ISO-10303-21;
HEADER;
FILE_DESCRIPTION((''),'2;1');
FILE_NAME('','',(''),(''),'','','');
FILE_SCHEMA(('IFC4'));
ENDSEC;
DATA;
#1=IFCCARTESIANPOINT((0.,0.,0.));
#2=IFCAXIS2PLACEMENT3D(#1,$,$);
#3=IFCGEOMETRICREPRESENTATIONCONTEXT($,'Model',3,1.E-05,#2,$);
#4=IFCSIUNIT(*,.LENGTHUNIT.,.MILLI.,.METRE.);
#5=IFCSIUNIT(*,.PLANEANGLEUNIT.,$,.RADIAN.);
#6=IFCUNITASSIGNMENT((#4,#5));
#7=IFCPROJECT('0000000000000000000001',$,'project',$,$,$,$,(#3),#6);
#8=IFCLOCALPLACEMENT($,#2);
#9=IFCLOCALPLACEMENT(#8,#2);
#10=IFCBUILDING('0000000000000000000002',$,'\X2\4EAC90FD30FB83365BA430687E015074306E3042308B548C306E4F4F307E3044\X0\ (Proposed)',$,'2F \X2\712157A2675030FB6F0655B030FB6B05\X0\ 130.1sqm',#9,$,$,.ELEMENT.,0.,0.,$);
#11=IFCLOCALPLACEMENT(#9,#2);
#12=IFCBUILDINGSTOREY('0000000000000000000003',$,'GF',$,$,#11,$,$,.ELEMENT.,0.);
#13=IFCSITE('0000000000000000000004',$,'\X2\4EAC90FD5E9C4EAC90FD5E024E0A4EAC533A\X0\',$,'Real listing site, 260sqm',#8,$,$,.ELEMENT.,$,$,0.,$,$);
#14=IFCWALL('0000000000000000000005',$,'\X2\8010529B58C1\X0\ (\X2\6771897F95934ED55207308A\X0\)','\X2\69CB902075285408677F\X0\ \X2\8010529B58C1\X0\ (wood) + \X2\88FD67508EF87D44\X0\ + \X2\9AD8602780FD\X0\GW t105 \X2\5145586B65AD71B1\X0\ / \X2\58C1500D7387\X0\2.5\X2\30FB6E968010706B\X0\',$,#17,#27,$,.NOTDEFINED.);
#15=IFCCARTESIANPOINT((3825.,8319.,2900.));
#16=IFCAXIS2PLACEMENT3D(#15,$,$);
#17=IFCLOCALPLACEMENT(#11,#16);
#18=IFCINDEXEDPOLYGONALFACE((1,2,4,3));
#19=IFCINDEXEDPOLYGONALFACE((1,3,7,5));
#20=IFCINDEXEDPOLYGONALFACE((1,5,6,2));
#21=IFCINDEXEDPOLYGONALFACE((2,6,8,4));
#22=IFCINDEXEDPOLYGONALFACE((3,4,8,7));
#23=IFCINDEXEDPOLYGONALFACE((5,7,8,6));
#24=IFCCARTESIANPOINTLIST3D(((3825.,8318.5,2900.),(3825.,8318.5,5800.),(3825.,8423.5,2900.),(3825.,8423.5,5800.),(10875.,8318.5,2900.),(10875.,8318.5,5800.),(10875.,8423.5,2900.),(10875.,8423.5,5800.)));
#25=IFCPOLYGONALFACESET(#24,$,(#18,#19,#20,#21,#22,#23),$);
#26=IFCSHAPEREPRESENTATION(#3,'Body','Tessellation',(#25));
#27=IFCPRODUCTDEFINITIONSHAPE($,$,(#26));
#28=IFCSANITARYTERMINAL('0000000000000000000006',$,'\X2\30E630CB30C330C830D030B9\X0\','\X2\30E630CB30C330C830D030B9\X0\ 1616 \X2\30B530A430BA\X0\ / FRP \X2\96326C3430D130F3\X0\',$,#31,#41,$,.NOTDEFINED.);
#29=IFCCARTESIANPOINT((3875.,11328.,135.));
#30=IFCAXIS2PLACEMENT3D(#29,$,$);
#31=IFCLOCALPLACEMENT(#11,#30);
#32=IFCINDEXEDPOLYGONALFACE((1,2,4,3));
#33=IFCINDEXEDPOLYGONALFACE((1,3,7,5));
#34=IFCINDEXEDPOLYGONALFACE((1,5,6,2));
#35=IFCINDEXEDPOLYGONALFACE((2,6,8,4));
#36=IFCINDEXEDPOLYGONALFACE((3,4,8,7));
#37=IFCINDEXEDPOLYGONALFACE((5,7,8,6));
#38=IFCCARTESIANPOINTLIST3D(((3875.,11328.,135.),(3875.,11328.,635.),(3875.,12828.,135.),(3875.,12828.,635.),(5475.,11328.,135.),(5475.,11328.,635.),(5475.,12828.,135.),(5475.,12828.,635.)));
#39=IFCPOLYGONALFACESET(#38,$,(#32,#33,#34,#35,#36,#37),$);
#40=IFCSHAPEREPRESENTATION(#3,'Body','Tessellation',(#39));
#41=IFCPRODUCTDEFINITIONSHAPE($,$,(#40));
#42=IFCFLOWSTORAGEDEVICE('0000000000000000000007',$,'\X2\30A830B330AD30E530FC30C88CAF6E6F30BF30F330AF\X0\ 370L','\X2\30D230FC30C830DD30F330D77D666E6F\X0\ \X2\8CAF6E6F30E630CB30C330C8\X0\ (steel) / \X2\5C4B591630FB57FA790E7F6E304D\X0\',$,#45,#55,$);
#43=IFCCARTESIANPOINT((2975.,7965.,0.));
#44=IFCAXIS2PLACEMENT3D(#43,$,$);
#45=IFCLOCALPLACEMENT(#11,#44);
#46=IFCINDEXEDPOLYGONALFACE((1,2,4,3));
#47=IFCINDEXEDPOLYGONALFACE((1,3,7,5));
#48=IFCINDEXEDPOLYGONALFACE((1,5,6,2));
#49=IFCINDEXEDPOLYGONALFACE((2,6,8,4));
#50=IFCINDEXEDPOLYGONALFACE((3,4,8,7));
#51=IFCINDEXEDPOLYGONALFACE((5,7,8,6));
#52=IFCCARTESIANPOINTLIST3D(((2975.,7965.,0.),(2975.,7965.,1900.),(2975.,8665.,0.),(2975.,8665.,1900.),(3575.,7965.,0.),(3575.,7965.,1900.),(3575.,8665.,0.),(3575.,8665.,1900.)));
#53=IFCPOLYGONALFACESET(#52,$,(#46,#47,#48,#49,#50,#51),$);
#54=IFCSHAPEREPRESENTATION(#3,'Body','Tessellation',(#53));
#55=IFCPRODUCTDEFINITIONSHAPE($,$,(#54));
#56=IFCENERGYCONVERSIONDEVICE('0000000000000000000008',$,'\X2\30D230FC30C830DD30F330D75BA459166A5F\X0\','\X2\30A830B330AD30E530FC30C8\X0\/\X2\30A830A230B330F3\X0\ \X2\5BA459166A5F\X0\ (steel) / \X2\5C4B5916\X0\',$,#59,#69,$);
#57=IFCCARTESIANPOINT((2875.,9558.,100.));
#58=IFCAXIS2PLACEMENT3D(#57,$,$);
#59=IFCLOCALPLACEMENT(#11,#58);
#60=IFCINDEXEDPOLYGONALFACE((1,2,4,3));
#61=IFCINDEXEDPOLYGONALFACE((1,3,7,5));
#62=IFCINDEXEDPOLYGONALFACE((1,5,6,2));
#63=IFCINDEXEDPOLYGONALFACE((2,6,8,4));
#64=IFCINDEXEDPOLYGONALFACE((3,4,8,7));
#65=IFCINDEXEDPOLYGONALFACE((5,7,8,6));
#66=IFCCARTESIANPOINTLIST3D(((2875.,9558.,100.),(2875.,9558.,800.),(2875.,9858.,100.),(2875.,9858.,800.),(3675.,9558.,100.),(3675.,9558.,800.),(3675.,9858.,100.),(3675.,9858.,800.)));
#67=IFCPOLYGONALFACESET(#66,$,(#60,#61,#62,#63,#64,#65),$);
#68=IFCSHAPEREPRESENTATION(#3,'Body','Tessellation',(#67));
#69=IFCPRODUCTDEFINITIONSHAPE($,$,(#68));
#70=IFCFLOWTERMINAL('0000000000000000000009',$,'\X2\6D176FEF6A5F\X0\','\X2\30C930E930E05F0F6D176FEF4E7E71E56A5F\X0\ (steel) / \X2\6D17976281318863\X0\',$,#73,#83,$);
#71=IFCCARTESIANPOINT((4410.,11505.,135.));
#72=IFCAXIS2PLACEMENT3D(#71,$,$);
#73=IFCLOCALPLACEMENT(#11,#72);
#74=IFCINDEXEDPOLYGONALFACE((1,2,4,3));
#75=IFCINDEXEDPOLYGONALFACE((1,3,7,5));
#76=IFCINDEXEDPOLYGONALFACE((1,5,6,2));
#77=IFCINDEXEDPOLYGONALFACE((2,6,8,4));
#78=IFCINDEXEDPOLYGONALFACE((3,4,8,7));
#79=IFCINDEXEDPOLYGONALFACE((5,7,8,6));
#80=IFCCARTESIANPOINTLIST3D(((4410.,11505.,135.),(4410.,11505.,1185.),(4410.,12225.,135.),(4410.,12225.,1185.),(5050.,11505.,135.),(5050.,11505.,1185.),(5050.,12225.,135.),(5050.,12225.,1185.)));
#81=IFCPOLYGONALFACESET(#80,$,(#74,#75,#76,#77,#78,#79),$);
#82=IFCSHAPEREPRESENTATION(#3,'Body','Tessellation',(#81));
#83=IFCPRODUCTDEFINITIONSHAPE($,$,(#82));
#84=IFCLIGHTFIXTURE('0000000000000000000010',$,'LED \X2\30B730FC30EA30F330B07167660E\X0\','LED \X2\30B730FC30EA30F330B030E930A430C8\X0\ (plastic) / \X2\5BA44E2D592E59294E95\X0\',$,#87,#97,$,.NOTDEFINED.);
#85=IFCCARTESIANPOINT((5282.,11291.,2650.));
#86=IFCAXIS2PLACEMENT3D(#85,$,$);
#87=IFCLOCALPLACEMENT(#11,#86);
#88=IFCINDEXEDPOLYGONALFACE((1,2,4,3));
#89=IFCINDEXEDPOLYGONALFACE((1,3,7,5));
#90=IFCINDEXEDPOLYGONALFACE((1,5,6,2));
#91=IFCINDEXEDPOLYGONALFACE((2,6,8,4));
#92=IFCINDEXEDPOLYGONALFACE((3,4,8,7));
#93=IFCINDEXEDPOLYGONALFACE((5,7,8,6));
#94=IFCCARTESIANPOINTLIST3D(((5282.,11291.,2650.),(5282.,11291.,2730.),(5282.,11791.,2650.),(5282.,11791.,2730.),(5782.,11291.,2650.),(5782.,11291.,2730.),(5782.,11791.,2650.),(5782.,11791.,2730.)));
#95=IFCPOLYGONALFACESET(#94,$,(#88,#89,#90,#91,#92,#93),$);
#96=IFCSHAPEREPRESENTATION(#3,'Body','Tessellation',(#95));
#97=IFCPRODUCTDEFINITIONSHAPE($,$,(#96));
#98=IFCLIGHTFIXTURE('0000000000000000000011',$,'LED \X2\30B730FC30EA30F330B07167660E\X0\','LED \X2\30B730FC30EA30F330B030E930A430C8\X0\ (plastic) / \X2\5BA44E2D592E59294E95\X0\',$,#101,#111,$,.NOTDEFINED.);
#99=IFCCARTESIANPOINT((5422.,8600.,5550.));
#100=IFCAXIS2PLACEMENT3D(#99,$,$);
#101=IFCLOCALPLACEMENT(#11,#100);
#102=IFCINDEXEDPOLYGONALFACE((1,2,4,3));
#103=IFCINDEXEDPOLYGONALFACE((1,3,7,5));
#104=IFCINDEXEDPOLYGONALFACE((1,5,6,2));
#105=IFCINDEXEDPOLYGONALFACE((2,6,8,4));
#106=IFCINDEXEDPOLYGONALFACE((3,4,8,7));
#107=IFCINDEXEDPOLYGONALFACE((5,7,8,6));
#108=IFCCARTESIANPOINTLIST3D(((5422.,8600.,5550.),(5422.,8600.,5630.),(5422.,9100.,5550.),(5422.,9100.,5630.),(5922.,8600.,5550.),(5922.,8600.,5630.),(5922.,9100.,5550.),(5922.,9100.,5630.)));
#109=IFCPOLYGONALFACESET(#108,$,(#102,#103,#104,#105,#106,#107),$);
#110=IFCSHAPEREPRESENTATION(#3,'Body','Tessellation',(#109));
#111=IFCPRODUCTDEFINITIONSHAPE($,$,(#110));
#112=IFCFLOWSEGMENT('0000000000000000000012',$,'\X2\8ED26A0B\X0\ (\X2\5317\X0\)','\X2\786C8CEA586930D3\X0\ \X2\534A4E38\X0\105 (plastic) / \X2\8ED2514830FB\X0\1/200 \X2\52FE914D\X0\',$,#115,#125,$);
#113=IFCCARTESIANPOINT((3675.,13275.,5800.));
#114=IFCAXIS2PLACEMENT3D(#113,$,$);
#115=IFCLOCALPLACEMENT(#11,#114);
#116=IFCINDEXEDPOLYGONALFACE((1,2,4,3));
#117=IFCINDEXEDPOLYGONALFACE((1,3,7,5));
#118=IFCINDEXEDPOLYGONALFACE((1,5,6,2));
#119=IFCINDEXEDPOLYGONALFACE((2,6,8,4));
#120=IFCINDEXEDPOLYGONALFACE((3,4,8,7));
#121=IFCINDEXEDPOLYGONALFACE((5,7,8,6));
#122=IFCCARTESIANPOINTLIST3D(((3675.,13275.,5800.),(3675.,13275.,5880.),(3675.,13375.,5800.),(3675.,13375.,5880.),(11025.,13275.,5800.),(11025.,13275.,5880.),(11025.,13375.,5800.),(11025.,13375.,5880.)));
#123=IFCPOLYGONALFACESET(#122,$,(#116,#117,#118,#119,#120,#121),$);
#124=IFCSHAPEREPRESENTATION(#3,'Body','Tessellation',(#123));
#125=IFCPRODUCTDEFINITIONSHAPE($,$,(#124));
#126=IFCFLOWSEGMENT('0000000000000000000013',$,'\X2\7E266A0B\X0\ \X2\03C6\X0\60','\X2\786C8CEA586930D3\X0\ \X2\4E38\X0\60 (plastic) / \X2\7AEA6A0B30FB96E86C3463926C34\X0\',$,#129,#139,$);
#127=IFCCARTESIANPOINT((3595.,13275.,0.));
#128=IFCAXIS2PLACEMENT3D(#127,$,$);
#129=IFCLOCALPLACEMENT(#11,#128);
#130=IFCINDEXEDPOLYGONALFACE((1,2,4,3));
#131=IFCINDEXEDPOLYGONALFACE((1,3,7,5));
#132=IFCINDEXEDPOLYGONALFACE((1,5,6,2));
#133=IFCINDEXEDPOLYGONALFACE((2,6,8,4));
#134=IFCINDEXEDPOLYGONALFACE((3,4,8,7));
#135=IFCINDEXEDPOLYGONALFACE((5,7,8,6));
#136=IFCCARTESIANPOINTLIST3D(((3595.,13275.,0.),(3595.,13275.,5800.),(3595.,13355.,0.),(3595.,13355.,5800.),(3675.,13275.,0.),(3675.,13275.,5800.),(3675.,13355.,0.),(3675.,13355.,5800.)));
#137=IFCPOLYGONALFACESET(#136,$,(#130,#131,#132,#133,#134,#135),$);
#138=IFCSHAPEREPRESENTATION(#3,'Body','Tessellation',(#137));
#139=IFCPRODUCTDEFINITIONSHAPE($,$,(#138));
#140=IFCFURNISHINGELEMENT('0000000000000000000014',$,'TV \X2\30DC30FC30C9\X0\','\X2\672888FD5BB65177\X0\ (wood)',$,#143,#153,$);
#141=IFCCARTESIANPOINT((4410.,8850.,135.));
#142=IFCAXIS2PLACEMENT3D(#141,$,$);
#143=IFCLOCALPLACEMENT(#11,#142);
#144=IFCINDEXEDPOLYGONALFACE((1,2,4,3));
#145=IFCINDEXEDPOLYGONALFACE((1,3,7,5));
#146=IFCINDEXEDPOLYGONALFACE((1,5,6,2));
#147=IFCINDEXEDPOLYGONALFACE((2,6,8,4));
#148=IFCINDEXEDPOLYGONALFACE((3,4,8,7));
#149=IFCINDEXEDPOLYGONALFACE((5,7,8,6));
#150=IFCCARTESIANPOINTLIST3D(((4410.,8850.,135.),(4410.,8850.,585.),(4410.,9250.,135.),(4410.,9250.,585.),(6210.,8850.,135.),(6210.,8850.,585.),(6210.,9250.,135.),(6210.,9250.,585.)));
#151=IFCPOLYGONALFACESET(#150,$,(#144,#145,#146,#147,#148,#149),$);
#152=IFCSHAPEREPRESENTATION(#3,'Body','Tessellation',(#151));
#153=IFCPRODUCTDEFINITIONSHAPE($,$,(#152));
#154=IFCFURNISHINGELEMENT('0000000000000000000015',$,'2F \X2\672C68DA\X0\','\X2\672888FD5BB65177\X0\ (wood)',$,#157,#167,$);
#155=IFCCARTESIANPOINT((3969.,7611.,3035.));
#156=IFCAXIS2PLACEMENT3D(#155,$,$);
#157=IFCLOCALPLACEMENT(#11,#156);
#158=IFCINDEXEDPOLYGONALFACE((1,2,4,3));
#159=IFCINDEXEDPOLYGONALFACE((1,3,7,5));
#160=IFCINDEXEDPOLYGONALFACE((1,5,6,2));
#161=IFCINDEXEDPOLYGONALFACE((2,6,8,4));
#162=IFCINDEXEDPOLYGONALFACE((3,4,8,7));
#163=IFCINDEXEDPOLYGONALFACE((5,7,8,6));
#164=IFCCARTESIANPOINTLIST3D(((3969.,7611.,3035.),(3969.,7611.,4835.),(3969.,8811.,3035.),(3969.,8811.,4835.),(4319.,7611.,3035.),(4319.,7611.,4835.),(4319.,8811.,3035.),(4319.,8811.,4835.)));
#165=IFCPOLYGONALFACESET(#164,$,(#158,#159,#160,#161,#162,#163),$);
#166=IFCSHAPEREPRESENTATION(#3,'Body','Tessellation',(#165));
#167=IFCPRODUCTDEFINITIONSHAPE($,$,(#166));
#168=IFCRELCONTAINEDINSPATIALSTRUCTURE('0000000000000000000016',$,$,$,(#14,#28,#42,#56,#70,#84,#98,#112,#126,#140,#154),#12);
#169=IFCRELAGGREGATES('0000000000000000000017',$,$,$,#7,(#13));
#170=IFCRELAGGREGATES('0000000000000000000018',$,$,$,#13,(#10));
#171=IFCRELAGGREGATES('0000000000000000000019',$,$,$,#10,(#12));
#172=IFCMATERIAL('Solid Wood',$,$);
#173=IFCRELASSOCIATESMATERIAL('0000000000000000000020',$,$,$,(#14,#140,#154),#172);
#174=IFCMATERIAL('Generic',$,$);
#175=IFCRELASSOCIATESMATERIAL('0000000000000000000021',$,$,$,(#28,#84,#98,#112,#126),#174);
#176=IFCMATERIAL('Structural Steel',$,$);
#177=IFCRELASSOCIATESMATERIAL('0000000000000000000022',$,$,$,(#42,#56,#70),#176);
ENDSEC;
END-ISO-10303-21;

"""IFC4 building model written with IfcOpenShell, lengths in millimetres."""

from ifc_helpers import new_model, si_unit, frame, frame_2d, origin, place, context, project, spatial, rectangle, extrude, material, element, save


model = new_model("IFC4")

# Units and contexts
model_context = context("Model", 3, precision=1e-05, world=origin())
ifc_project = project(units=[si_unit("LENGTHUNIT", "METRE", prefix="MILLI"), si_unit("PLANEANGLEUNIT", "RADIAN")], contexts=[model_context])

# Site, building, storey
site_placement = place(None, origin())
site = spatial("IfcSite", under=ifc_project, at=site_placement, Name="京都府京都市上京区", ObjectType="Real listing site, 260sqm", CompositionType="ELEMENT", RefElevation=0.0)
building_placement = place(site_placement, origin())
building = spatial("IfcBuilding", under=site, at=building_placement, Name="京都・茶室と縁側のある和の住まい (Proposed)", ObjectType="2F 無垢材・漆喰・欅 130.1sqm", CompositionType="ELEMENT", ElevationOfRefHeight=0.0, ElevationOfTerrain=0.0)
storey_placement = place(building_placement, origin())
storey = spatial("IfcBuildingStorey", under=building, at=storey_placement, Name="GF", CompositionType="ELEMENT", Elevation=0.0)

# Shared definitions
ifc_material_1 = material(Name="Solid Wood")

# Wall
wall_1_placement = place(storey_placement, frame((3825.0, 8319.0, 2900.0)))
element("IfcWall", 1, at=wall_1_placement, inside=storey, material=ifc_material_1, Name="耐力壁 (東西間仕切り)", Description="構造用合板 耐力壁 (wood) + 製材軸組 + 高性能GW t105 充填断熱 / 壁倍率2.5・準耐火", PredefinedType="NOTDEFINED", context=model_context, shape_type="SweptSolid", body=[
    extrude(rectangle(XDim=7050.0, YDim=105.0, at=frame_2d((3525.0, 52.0))), frame((3825.0, 8319.0, 2900.0)), (0.0, 0.0, 1.0), 2900.0),
])

# Sanitary terminal
ifc_material_2 = material(Name="Generic")
sanitary_terminal_placement = place(storey_placement, frame((3875.0, 11328.0, 135.0)))
element("IfcSanitaryTerminal", 2, at=sanitary_terminal_placement, inside=storey, material=ifc_material_2, Name="ユニットバス", Description="ユニットバス 1616 サイズ / FRP 防水パン", PredefinedType="NOTDEFINED", context=model_context, shape_type="SweptSolid", body=[
    extrude(rectangle(XDim=1600.0, YDim=1500.0, at=frame_2d((800.0, 750.0))), frame((3875.0, 11328.0, 135.0)), (0.0, 0.0, 1.0), 500.0),
])

# Flow storage device
ifc_material_3 = material(Name="Structural Steel")
flow_storage_device_placement = place(storey_placement, frame((2975.0, 7965.0, 0.0)))
element("IfcFlowStorageDevice", 3, at=flow_storage_device_placement, inside=storey, material=ifc_material_3, Name="エコキュート貯湯タンク 370L", Description="ヒートポンプ給湯 貯湯ユニット (steel) / 屋外・基礎置き", context=model_context, shape_type="SweptSolid", body=[
    extrude(rectangle(XDim=600.0, YDim=700.0, at=frame_2d((300.0, 350.0))), frame((2975.0, 7965.0, 0.0)), (0.0, 0.0, 1.0), 1900.0),
])

# Energy conversion device
energy_conversion_device_placement = place(storey_placement, frame((2875.0, 9558.0, 100.0)))
element("IfcEnergyConversionDevice", 4, at=energy_conversion_device_placement, inside=storey, material=ifc_material_3, Name="ヒートポンプ室外機", Description="エコキュート/エアコン 室外機 (steel) / 屋外", context=model_context, shape_type="SweptSolid", body=[
    extrude(rectangle(XDim=800.0, YDim=300.0, at=frame_2d((400.0, 150.0))), frame((2875.0, 9558.0, 100.0)), (0.0, 0.0, 1.0), 700.0),
])

# Flow terminal
flow_terminal_placement = place(storey_placement, frame((4410.0, 11505.0, 135.0)))
element("IfcFlowTerminal", 5, at=flow_terminal_placement, inside=storey, material=ifc_material_3, Name="洗濯機", Description="ドラム式洗濯乾燥機 (steel) / 洗面脱衣", context=model_context, shape_type="SweptSolid", body=[
    extrude(rectangle(XDim=640.0, YDim=720.0, at=frame_2d((320.0, 360.0))), frame((4410.0, 11505.0, 135.0)), (0.0, 0.0, 1.0), 1050.0),
])

# Light fixtures
light_fixture_1_placement = place(storey_placement, frame((5282.0, 11291.0, 2650.0)))
element("IfcLightFixture", 6, at=light_fixture_1_placement, inside=storey, material=ifc_material_2, Name="LED シーリング照明", Description="LED シーリングライト (plastic) / 室中央天井", PredefinedType="NOTDEFINED", context=model_context, shape_type="SweptSolid", body=[
    extrude(rectangle(XDim=500.0, YDim=500.0, at=frame_2d((250.0, 250.0))), frame((5282.0, 11291.0, 2650.0)), (0.0, 0.0, 1.0), 80.0),
])
light_fixture_2_placement = place(storey_placement, frame((5422.0, 8600.0, 5550.0)))
element("IfcLightFixture", 7, at=light_fixture_2_placement, inside=storey, material=ifc_material_2, Name="LED シーリング照明", Description="LED シーリングライト (plastic) / 室中央天井", PredefinedType="NOTDEFINED", context=model_context, shape_type="SweptSolid", body=[
    extrude(rectangle(XDim=500.0, YDim=500.0, at=frame_2d((250.0, 250.0))), frame((5422.0, 8600.0, 5550.0)), (0.0, 0.0, 1.0), 80.0),
])

# Flow segments
flow_segment_1_placement = place(storey_placement, frame((3675.0, 13275.0, 5800.0)))
element("IfcFlowSegment", 8, at=flow_segment_1_placement, inside=storey, material=ifc_material_2, Name="軒樋 (北)", Description="硬質塩ビ 半丸105 (plastic) / 軒先・1/200 勾配", context=model_context, shape_type="SweptSolid", body=[
    extrude(rectangle(XDim=7350.0, YDim=100.0, at=frame_2d((3675.0, 50.0))), frame((3675.0, 13275.0, 5800.0)), (0.0, 0.0, 1.0), 80.0),
])
flow_segment_2_placement = place(storey_placement, frame((3595.0, 13275.0, 0.0)))
element("IfcFlowSegment", 9, at=flow_segment_2_placement, inside=storey, material=ifc_material_2, Name="縦樋 φ60", Description="硬質塩ビ 丸60 (plastic) / 竪樋・雨水排水", context=model_context, shape_type="SweptSolid", body=[
    extrude(rectangle(XDim=80.0, YDim=80.0, at=frame_2d((40.0, 40.0))), frame((3595.0, 13275.0, 0.0)), (0.0, 0.0, 1.0), 5800.0),
])

# Furnishing elements
furnishing_1_placement = place(storey_placement, frame((4410.0, 8850.0, 135.0)))
element("IfcFurnishingElement", 10, at=furnishing_1_placement, inside=storey, material=ifc_material_1, Name="TV ボード", Description="木製家具 (wood)", context=model_context, shape_type="SweptSolid", body=[
    extrude(rectangle(XDim=1800.0, YDim=400.0, at=frame_2d((900.0, 200.0))), frame((4410.0, 8850.0, 135.0)), (0.0, 0.0, 1.0), 450.0),
])
furnishing_2_placement = place(storey_placement, frame((3969.0, 7611.0, 3035.0)))
element("IfcFurnishingElement", 11, at=furnishing_2_placement, inside=storey, material=ifc_material_1, Name="2F 本棚", Description="木製家具 (wood)", context=model_context, shape_type="SweptSolid", body=[
    extrude(rectangle(XDim=350.0, YDim=1200.0, at=frame_2d((175.0, 600.0))), frame((3969.0, 7611.0, 3035.0)), (0.0, 0.0, 1.0), 1800.0),
])

save(model, "model.ifc")
